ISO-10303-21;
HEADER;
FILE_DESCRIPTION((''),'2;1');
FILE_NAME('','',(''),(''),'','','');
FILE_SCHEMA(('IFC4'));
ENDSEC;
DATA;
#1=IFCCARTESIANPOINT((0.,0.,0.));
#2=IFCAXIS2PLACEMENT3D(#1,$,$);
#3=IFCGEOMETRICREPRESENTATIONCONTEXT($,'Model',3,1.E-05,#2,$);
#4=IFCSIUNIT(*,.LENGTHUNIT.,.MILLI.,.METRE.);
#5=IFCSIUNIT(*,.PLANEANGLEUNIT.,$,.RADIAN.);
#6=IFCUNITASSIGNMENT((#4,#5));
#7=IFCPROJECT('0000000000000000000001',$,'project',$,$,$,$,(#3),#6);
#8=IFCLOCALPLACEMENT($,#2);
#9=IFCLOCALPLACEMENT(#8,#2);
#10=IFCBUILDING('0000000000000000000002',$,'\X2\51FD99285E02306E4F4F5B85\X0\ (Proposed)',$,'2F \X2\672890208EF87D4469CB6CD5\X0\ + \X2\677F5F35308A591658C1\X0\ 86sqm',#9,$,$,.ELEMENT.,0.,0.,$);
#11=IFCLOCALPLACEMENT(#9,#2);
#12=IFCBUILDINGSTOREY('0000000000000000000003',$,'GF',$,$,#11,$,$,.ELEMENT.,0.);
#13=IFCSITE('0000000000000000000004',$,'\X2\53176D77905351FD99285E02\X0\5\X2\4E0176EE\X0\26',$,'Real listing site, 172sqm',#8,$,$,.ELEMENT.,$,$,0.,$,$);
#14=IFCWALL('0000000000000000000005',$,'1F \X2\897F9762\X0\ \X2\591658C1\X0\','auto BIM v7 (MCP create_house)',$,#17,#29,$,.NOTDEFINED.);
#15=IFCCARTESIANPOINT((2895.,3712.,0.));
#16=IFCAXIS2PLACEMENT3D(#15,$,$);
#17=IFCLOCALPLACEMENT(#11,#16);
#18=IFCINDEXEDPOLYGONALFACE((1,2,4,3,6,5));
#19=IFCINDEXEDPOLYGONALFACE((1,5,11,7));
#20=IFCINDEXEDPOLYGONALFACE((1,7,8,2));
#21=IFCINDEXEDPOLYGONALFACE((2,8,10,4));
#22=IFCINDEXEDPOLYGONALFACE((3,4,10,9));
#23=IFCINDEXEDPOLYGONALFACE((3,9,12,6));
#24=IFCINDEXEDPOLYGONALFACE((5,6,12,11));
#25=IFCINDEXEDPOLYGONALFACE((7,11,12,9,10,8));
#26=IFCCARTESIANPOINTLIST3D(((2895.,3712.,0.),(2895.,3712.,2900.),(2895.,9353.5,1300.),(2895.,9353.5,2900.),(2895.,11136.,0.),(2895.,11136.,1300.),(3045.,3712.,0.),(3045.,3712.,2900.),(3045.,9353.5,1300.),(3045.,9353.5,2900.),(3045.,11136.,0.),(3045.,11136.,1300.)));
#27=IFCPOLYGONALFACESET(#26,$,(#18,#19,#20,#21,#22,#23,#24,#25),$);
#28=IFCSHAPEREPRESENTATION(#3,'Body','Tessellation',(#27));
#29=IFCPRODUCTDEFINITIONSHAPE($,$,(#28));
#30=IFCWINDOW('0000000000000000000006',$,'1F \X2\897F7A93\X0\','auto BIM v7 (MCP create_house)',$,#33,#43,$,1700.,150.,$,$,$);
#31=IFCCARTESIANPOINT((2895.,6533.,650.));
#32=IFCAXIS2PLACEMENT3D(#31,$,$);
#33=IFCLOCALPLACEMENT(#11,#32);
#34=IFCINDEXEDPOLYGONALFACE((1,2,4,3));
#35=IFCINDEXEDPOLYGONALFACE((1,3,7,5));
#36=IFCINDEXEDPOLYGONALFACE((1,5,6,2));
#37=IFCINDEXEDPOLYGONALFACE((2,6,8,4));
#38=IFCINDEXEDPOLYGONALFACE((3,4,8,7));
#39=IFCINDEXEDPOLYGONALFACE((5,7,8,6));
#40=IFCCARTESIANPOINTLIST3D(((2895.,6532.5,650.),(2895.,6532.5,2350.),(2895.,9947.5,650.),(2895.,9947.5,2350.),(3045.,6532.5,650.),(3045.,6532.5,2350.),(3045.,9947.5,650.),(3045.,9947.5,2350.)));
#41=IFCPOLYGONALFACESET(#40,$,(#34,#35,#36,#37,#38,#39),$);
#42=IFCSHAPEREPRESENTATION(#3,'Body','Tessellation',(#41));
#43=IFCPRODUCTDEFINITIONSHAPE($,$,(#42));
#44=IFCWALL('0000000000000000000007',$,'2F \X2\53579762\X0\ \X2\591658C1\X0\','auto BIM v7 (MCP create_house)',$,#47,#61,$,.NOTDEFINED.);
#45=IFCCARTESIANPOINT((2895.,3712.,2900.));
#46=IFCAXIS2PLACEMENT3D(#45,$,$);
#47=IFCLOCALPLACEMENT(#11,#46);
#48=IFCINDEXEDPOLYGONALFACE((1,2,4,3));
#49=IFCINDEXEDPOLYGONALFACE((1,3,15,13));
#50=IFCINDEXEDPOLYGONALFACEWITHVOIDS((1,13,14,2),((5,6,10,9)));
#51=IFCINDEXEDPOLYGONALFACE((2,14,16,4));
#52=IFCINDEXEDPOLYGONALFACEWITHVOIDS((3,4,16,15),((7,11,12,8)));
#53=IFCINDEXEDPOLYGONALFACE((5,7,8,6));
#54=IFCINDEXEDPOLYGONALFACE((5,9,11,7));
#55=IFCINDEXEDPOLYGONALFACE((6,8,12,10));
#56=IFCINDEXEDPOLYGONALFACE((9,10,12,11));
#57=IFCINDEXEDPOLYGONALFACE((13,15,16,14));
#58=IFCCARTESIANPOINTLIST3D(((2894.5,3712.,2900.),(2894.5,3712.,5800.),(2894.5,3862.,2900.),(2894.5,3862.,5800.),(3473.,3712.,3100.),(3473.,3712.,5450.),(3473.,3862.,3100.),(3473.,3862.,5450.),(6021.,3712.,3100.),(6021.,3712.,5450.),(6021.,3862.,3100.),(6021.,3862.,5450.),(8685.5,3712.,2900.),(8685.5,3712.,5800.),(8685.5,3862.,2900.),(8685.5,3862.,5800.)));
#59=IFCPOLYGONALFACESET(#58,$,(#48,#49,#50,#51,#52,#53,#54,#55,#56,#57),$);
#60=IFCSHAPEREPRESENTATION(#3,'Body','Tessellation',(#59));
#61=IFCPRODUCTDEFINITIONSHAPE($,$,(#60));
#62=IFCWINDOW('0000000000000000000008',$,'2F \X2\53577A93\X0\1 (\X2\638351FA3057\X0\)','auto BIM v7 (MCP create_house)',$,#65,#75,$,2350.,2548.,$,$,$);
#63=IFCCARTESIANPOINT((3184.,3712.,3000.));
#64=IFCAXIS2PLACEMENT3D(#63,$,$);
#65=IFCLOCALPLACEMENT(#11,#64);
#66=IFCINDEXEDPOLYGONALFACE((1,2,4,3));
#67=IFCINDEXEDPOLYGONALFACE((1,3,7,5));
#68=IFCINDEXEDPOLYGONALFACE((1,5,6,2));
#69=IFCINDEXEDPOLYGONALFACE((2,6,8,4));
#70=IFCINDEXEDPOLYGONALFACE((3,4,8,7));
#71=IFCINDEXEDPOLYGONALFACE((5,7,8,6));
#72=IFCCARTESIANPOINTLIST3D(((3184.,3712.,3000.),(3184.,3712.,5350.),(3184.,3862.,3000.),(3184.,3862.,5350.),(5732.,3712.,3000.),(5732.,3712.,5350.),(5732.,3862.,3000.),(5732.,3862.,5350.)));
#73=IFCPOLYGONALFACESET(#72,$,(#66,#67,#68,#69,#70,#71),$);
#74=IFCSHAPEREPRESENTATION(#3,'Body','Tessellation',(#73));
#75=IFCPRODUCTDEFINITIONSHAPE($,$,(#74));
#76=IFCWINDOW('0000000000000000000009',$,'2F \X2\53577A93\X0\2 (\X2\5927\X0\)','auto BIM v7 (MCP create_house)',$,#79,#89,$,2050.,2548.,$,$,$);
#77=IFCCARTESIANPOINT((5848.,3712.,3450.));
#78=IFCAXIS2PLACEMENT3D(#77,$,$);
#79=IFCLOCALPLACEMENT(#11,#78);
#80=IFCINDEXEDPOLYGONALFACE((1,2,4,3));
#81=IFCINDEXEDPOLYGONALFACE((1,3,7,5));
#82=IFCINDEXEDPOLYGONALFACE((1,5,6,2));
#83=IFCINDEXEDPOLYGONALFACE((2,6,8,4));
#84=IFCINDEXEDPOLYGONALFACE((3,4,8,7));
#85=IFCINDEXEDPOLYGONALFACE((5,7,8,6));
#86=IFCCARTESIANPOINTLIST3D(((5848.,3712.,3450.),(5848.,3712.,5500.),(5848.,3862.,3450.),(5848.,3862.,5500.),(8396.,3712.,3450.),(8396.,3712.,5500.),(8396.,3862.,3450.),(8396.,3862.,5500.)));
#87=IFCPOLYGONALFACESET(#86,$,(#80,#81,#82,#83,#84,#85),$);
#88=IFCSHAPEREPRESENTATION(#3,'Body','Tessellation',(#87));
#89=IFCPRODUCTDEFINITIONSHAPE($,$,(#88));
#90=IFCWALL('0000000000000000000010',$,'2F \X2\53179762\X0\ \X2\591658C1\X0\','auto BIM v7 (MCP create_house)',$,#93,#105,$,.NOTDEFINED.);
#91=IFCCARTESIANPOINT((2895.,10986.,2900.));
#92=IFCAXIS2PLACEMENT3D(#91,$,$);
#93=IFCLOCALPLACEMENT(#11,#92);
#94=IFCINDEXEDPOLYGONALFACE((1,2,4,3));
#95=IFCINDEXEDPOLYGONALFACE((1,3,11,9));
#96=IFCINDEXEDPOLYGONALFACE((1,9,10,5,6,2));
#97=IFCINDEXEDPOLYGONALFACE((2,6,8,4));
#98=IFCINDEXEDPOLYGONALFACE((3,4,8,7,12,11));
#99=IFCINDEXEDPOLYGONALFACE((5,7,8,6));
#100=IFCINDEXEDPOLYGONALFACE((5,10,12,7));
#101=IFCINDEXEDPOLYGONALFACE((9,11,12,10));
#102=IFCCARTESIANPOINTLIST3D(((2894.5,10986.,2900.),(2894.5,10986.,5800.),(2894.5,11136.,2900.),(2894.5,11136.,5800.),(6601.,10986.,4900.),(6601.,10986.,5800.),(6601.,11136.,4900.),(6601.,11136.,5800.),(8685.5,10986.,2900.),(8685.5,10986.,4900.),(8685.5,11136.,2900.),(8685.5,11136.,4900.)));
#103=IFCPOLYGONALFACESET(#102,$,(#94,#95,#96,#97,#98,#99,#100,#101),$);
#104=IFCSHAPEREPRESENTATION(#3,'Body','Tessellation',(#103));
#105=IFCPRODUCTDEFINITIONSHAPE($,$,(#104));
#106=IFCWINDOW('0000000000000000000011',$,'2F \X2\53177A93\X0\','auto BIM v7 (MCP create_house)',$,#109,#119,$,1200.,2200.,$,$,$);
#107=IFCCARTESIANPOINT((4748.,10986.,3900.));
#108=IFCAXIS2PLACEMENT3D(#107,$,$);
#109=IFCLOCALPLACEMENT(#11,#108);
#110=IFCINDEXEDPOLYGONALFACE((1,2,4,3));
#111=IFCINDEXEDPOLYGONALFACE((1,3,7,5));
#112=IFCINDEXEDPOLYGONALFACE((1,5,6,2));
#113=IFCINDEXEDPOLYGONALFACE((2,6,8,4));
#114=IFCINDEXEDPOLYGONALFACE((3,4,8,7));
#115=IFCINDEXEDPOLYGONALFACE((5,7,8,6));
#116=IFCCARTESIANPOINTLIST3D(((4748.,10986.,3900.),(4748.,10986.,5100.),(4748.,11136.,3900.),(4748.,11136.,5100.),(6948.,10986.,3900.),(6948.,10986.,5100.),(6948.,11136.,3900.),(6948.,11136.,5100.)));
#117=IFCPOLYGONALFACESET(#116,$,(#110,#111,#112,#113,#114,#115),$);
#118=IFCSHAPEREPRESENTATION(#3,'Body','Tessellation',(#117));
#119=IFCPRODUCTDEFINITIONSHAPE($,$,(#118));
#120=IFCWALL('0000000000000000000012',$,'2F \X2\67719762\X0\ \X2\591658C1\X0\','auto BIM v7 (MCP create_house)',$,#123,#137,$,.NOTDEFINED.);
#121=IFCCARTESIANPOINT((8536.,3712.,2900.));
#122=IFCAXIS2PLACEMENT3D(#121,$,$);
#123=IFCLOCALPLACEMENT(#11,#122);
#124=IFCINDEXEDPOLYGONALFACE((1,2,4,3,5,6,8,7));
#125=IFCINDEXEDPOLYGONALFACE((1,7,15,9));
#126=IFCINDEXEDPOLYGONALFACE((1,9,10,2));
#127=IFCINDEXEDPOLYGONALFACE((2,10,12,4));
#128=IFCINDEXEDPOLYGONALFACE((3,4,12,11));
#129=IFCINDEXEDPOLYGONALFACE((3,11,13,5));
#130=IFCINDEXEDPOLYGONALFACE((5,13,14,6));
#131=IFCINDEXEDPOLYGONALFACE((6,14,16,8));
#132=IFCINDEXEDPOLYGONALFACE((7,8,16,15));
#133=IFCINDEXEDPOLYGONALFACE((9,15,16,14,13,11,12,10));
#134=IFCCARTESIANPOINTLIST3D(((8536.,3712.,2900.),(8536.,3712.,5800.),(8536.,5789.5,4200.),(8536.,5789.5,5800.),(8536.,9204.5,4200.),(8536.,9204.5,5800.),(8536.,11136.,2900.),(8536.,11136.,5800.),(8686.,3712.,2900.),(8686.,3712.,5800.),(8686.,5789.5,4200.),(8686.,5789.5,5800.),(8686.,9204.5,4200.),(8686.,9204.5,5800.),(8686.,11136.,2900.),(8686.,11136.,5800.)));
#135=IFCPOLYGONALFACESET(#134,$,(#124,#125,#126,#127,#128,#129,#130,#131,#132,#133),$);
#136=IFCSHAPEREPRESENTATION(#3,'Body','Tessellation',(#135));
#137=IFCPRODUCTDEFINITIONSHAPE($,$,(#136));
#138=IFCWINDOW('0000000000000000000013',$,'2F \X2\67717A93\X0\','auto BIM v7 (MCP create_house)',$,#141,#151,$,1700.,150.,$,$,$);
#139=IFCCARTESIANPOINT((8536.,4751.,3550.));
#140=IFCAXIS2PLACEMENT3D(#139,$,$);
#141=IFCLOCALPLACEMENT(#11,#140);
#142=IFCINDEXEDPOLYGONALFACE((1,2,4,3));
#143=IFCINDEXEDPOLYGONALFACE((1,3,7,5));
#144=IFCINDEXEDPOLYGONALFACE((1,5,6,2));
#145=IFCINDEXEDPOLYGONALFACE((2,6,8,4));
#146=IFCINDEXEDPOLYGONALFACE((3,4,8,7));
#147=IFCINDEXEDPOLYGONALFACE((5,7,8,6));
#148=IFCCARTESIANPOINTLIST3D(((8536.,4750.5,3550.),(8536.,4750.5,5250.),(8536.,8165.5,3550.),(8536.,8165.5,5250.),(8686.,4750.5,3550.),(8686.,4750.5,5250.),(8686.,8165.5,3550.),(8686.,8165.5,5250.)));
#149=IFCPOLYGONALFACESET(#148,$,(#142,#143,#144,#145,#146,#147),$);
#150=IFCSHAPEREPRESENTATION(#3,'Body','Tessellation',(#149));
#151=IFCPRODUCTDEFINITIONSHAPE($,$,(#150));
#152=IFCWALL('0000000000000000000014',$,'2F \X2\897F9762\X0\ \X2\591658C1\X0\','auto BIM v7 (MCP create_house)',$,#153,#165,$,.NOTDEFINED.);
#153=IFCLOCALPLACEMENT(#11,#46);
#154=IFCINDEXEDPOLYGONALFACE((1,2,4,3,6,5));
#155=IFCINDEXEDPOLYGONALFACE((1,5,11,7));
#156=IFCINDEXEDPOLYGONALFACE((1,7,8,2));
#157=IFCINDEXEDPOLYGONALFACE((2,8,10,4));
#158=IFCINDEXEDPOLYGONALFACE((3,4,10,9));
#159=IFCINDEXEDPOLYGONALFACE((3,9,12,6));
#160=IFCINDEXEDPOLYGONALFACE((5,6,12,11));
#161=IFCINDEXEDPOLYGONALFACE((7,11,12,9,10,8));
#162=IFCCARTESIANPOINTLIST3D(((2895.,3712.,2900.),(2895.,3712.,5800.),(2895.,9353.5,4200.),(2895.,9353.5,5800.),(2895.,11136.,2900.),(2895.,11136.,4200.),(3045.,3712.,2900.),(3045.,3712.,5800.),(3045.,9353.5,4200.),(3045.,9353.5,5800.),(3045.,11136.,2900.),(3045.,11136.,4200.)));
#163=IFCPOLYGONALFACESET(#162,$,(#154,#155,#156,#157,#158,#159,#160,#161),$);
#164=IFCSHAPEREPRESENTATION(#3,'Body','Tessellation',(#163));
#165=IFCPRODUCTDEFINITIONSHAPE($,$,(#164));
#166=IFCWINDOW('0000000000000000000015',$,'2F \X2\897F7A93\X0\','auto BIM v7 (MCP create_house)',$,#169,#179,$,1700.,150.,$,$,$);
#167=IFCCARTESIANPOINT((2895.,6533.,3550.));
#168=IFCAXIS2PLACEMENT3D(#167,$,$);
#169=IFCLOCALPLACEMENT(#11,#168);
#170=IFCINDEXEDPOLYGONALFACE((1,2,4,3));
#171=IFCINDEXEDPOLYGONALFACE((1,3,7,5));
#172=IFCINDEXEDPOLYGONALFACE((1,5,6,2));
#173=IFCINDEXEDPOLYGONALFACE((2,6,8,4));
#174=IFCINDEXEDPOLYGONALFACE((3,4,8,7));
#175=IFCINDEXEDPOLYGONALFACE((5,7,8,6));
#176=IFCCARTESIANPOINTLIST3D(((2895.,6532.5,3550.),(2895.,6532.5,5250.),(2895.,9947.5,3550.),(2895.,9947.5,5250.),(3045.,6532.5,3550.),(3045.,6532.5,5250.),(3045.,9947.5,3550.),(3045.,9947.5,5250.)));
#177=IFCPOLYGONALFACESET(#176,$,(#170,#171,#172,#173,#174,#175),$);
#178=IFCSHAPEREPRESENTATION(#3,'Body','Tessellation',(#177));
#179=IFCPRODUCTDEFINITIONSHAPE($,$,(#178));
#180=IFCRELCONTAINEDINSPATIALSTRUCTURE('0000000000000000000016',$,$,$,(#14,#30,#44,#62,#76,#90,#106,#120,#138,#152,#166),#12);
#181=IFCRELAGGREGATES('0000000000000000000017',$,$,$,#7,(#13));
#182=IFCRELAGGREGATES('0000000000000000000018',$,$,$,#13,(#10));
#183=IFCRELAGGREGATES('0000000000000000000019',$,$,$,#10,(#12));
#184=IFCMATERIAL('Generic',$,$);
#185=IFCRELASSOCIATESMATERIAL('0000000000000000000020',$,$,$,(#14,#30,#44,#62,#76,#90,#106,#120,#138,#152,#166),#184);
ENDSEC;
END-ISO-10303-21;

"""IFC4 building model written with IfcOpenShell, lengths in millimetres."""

from ifc_helpers import new_model, si_unit, frame, frame_2d, origin, place, context, project, spatial, rectangle, extrude, material, element, fill, save


model = new_model("IFC4")

# Units and contexts
model_context = context("Model", 3, precision=1e-05, world=origin())
ifc_project = project(units=[si_unit("LENGTHUNIT", "METRE", prefix="MILLI"), si_unit("PLANEANGLEUNIT", "RADIAN")], contexts=[model_context])

# Site, building, storey
site_placement = place(None, origin())
site = spatial("IfcSite", under=ifc_project, at=site_placement, Name="北海道函館市5丁目26", ObjectType="Real listing site, 172sqm", CompositionType="ELEMENT", RefElevation=0.0)
building_placement = place(site_placement, origin())
building = spatial("IfcBuilding", under=site, at=building_placement, Name="函館市の住宅 (Proposed)", ObjectType="2F 木造軸組構法 + 板張り外壁 86sqm", CompositionType="ELEMENT", ElevationOfRefHeight=0.0, ElevationOfTerrain=0.0)
storey_placement = place(building_placement, origin())
storey = spatial("IfcBuildingStorey", under=building, at=storey_placement, Name="GF", CompositionType="ELEMENT", Elevation=0.0)

# Shared definitions
ifc_material = material(Name="Generic")

# Wall, opening, window
wall_1_placement = place(storey_placement, frame((2895.0, 3712.0, 0.0)))
wall_1 = element("IfcWall", 1, at=wall_1_placement, inside=storey, material=ifc_material, Name="1F 西面 外壁", Description="auto BIM v7 (MCP create_house)", PredefinedType="NOTDEFINED", context=model_context, shape_type="SweptSolid", body=[
    extrude(rectangle(XDim=150.0, YDim=7424.0, at=frame_2d((75.0, 3712.0))), frame((2895.0, 3712.0, 0.0)), (0.0, 0.0, 1.0), 2900.0),
])
opening_1_placement = place(storey_placement, frame((2895.0, 6533.0, 650.0)))
opening_1 = element("IfcOpeningElement", 2, at=opening_1_placement, cuts=wall_1, PredefinedType="NOTDEFINED", context=model_context, shape_type="SweptSolid", body=[
    extrude(rectangle(XDim=150.0, YDim=3415.0, at=frame_2d((75.0, 1707.0))), frame((2895.0, 6533.0, 650.0)), (0.0, 0.0, 1.0), 1700.0),
])
window_1_placement = place(storey_placement, frame((2895.0, 6533.0, 650.0)))
window_1 = element("IfcWindow", 3, at=window_1_placement, inside=storey, material=ifc_material, Name="1F 西窓", Description="auto BIM v7 (MCP create_house)", OverallHeight=1700.0, OverallWidth=150.0, context=model_context, shape_type="SweptSolid", body=[
    extrude(rectangle(XDim=150.0, YDim=3415.0, at=frame_2d((75.0, 1707.0))), frame((2895.0, 6533.0, 650.0)), (0.0, 0.0, 1.0), 1700.0),
])
fill(opening_1, window_1)

# Wall, openings, windows
wall_2_placement = place(storey_placement, frame((2895.0, 3712.0, 2900.0)))
wall_2 = element("IfcWall", 4, at=wall_2_placement, inside=storey, material=ifc_material, Name="2F 南面 外壁", Description="auto BIM v7 (MCP create_house)", PredefinedType="NOTDEFINED", context=model_context, shape_type="SweptSolid", body=[
    extrude(rectangle(XDim=5791.0, YDim=150.0, at=frame_2d((2895.0, 75.0))), frame((2895.0, 3712.0, 2900.0)), (0.0, 0.0, 1.0), 2900.0),
])
opening_2_placement = place(storey_placement, frame((3184.0, 3712.0, 3000.0)))
opening_2 = element("IfcOpeningElement", 5, at=opening_2_placement, cuts=wall_2, PredefinedType="NOTDEFINED", context=model_context, shape_type="SweptSolid", body=[
    extrude(rectangle(XDim=2548.0, YDim=150.0, at=frame_2d((1274.0, 75.0))), frame((3184.0, 3712.0, 3000.0)), (0.0, 0.0, 1.0), 2350.0),
])
opening_3_placement = place(storey_placement, frame((5848.0, 3712.0, 3450.0)))
opening_3 = element("IfcOpeningElement", 6, at=opening_3_placement, cuts=wall_2, PredefinedType="NOTDEFINED", context=model_context, shape_type="SweptSolid", body=[
    extrude(rectangle(XDim=2548.0, YDim=150.0, at=frame_2d((1274.0, 75.0))), frame((5848.0, 3712.0, 3450.0)), (0.0, 0.0, 1.0), 2050.0),
])
window_2_placement = place(storey_placement, frame((3184.0, 3712.0, 3000.0)))
window_2 = element("IfcWindow", 7, at=window_2_placement, inside=storey, material=ifc_material, Name="2F 南窓1 (掃出し)", Description="auto BIM v7 (MCP create_house)", OverallHeight=2350.0, OverallWidth=2548.0, context=model_context, shape_type="SweptSolid", body=[
    extrude(rectangle(XDim=2548.0, YDim=150.0, at=frame_2d((1274.0, 75.0))), frame((3184.0, 3712.0, 3000.0)), (0.0, 0.0, 1.0), 2350.0),
])
fill(opening_2, window_2)
window_3_placement = place(storey_placement, frame((5848.0, 3712.0, 3450.0)))
window_3 = element("IfcWindow", 8, at=window_3_placement, inside=storey, material=ifc_material, Name="2F 南窓2 (大)", Description="auto BIM v7 (MCP create_house)", OverallHeight=2050.0, OverallWidth=2548.0, context=model_context, shape_type="SweptSolid", body=[
    extrude(rectangle(XDim=2548.0, YDim=150.0, at=frame_2d((1274.0, 75.0))), frame((5848.0, 3712.0, 3450.0)), (0.0, 0.0, 1.0), 2050.0),
])
fill(opening_3, window_3)

# Walls, openings, windows
wall_3_placement = place(storey_placement, frame((2895.0, 10986.0, 2900.0)))
wall_3 = element("IfcWall", 9, at=wall_3_placement, inside=storey, material=ifc_material, Name="2F 北面 外壁", Description="auto BIM v7 (MCP create_house)", PredefinedType="NOTDEFINED", context=model_context, shape_type="SweptSolid", body=[
    extrude(rectangle(XDim=5791.0, YDim=150.0, at=frame_2d((2895.0, 75.0))), frame((2895.0, 10986.0, 2900.0)), (0.0, 0.0, 1.0), 2900.0),
])
opening_4_placement = place(storey_placement, frame((4748.0, 10986.0, 3900.0)))
opening_4 = element("IfcOpeningElement", 10, at=opening_4_placement, cuts=wall_3, PredefinedType="NOTDEFINED", context=model_context, shape_type="SweptSolid", body=[
    extrude(rectangle(XDim=2200.0, YDim=150.0, at=frame_2d((1100.0, 75.0))), frame((4748.0, 10986.0, 3900.0)), (0.0, 0.0, 1.0), 1200.0),
])
window_4_placement = place(storey_placement, frame((4748.0, 10986.0, 3900.0)))
window_4 = element("IfcWindow", 11, at=window_4_placement, inside=storey, material=ifc_material, Name="2F 北窓", Description="auto BIM v7 (MCP create_house)", OverallHeight=1200.0, OverallWidth=2200.0, context=model_context, shape_type="SweptSolid", body=[
    extrude(rectangle(XDim=2200.0, YDim=150.0, at=frame_2d((1100.0, 75.0))), frame((4748.0, 10986.0, 3900.0)), (0.0, 0.0, 1.0), 1200.0),
])
fill(opening_4, window_4)
wall_4_placement = place(storey_placement, frame((8536.0, 3712.0, 2900.0)))
wall_4 = element("IfcWall", 12, at=wall_4_placement, inside=storey, material=ifc_material, Name="2F 東面 外壁", Description="auto BIM v7 (MCP create_house)", PredefinedType="NOTDEFINED", context=model_context, shape_type="SweptSolid", body=[
    extrude(rectangle(XDim=150.0, YDim=7424.0, at=frame_2d((75.0, 3712.0))), frame((8536.0, 3712.0, 2900.0)), (0.0, 0.0, 1.0), 2900.0),
])
opening_5_placement = place(storey_placement, frame((8536.0, 4751.0, 3550.0)))
opening_5 = element("IfcOpeningElement", 13, at=opening_5_placement, cuts=wall_4, PredefinedType="NOTDEFINED", context=model_context, shape_type="SweptSolid", body=[
    extrude(rectangle(XDim=150.0, YDim=3415.0, at=frame_2d((75.0, 1707.0))), frame((8536.0, 4751.0, 3550.0)), (0.0, 0.0, 1.0), 1700.0),
])
window_5_placement = place(storey_placement, frame((8536.0, 4751.0, 3550.0)))
window_5 = element("IfcWindow", 14, at=window_5_placement, inside=storey, material=ifc_material, Name="2F 東窓", Description="auto BIM v7 (MCP create_house)", OverallHeight=1700.0, OverallWidth=150.0, context=model_context, shape_type="SweptSolid", body=[
    extrude(rectangle(XDim=150.0, YDim=3415.0, at=frame_2d((75.0, 1707.0))), frame((8536.0, 4751.0, 3550.0)), (0.0, 0.0, 1.0), 1700.0),
])
fill(opening_5, window_5)
wall_5_placement = place(storey_placement, frame((2895.0, 3712.0, 2900.0)))
wall_5 = element("IfcWall", 15, at=wall_5_placement, inside=storey, material=ifc_material, Name="2F 西面 外壁", Description="auto BIM v7 (MCP create_house)", PredefinedType="NOTDEFINED", context=model_context, shape_type="SweptSolid", body=[
    extrude(rectangle(XDim=150.0, YDim=7424.0, at=frame_2d((75.0, 3712.0))), frame((2895.0, 3712.0, 2900.0)), (0.0, 0.0, 1.0), 2900.0),
])
opening_6_placement = place(storey_placement, frame((2895.0, 6533.0, 3550.0)))
opening_6 = element("IfcOpeningElement", 16, at=opening_6_placement, cuts=wall_5, PredefinedType="NOTDEFINED", context=model_context, shape_type="SweptSolid", body=[
    extrude(rectangle(XDim=150.0, YDim=3415.0, at=frame_2d((75.0, 1707.0))), frame((2895.0, 6533.0, 3550.0)), (0.0, 0.0, 1.0), 1700.0),
])
window_6_placement = place(storey_placement, frame((2895.0, 6533.0, 3550.0)))
window_6 = element("IfcWindow", 17, at=window_6_placement, inside=storey, material=ifc_material, Name="2F 西窓", Description="auto BIM v7 (MCP create_house)", OverallHeight=1700.0, OverallWidth=150.0, context=model_context, shape_type="SweptSolid", body=[
    extrude(rectangle(XDim=150.0, YDim=3415.0, at=frame_2d((75.0, 1707.0))), frame((2895.0, 6533.0, 3550.0)), (0.0, 0.0, 1.0), 1700.0),
])
fill(opening_6, window_6)

save(model, "model.ifc")
